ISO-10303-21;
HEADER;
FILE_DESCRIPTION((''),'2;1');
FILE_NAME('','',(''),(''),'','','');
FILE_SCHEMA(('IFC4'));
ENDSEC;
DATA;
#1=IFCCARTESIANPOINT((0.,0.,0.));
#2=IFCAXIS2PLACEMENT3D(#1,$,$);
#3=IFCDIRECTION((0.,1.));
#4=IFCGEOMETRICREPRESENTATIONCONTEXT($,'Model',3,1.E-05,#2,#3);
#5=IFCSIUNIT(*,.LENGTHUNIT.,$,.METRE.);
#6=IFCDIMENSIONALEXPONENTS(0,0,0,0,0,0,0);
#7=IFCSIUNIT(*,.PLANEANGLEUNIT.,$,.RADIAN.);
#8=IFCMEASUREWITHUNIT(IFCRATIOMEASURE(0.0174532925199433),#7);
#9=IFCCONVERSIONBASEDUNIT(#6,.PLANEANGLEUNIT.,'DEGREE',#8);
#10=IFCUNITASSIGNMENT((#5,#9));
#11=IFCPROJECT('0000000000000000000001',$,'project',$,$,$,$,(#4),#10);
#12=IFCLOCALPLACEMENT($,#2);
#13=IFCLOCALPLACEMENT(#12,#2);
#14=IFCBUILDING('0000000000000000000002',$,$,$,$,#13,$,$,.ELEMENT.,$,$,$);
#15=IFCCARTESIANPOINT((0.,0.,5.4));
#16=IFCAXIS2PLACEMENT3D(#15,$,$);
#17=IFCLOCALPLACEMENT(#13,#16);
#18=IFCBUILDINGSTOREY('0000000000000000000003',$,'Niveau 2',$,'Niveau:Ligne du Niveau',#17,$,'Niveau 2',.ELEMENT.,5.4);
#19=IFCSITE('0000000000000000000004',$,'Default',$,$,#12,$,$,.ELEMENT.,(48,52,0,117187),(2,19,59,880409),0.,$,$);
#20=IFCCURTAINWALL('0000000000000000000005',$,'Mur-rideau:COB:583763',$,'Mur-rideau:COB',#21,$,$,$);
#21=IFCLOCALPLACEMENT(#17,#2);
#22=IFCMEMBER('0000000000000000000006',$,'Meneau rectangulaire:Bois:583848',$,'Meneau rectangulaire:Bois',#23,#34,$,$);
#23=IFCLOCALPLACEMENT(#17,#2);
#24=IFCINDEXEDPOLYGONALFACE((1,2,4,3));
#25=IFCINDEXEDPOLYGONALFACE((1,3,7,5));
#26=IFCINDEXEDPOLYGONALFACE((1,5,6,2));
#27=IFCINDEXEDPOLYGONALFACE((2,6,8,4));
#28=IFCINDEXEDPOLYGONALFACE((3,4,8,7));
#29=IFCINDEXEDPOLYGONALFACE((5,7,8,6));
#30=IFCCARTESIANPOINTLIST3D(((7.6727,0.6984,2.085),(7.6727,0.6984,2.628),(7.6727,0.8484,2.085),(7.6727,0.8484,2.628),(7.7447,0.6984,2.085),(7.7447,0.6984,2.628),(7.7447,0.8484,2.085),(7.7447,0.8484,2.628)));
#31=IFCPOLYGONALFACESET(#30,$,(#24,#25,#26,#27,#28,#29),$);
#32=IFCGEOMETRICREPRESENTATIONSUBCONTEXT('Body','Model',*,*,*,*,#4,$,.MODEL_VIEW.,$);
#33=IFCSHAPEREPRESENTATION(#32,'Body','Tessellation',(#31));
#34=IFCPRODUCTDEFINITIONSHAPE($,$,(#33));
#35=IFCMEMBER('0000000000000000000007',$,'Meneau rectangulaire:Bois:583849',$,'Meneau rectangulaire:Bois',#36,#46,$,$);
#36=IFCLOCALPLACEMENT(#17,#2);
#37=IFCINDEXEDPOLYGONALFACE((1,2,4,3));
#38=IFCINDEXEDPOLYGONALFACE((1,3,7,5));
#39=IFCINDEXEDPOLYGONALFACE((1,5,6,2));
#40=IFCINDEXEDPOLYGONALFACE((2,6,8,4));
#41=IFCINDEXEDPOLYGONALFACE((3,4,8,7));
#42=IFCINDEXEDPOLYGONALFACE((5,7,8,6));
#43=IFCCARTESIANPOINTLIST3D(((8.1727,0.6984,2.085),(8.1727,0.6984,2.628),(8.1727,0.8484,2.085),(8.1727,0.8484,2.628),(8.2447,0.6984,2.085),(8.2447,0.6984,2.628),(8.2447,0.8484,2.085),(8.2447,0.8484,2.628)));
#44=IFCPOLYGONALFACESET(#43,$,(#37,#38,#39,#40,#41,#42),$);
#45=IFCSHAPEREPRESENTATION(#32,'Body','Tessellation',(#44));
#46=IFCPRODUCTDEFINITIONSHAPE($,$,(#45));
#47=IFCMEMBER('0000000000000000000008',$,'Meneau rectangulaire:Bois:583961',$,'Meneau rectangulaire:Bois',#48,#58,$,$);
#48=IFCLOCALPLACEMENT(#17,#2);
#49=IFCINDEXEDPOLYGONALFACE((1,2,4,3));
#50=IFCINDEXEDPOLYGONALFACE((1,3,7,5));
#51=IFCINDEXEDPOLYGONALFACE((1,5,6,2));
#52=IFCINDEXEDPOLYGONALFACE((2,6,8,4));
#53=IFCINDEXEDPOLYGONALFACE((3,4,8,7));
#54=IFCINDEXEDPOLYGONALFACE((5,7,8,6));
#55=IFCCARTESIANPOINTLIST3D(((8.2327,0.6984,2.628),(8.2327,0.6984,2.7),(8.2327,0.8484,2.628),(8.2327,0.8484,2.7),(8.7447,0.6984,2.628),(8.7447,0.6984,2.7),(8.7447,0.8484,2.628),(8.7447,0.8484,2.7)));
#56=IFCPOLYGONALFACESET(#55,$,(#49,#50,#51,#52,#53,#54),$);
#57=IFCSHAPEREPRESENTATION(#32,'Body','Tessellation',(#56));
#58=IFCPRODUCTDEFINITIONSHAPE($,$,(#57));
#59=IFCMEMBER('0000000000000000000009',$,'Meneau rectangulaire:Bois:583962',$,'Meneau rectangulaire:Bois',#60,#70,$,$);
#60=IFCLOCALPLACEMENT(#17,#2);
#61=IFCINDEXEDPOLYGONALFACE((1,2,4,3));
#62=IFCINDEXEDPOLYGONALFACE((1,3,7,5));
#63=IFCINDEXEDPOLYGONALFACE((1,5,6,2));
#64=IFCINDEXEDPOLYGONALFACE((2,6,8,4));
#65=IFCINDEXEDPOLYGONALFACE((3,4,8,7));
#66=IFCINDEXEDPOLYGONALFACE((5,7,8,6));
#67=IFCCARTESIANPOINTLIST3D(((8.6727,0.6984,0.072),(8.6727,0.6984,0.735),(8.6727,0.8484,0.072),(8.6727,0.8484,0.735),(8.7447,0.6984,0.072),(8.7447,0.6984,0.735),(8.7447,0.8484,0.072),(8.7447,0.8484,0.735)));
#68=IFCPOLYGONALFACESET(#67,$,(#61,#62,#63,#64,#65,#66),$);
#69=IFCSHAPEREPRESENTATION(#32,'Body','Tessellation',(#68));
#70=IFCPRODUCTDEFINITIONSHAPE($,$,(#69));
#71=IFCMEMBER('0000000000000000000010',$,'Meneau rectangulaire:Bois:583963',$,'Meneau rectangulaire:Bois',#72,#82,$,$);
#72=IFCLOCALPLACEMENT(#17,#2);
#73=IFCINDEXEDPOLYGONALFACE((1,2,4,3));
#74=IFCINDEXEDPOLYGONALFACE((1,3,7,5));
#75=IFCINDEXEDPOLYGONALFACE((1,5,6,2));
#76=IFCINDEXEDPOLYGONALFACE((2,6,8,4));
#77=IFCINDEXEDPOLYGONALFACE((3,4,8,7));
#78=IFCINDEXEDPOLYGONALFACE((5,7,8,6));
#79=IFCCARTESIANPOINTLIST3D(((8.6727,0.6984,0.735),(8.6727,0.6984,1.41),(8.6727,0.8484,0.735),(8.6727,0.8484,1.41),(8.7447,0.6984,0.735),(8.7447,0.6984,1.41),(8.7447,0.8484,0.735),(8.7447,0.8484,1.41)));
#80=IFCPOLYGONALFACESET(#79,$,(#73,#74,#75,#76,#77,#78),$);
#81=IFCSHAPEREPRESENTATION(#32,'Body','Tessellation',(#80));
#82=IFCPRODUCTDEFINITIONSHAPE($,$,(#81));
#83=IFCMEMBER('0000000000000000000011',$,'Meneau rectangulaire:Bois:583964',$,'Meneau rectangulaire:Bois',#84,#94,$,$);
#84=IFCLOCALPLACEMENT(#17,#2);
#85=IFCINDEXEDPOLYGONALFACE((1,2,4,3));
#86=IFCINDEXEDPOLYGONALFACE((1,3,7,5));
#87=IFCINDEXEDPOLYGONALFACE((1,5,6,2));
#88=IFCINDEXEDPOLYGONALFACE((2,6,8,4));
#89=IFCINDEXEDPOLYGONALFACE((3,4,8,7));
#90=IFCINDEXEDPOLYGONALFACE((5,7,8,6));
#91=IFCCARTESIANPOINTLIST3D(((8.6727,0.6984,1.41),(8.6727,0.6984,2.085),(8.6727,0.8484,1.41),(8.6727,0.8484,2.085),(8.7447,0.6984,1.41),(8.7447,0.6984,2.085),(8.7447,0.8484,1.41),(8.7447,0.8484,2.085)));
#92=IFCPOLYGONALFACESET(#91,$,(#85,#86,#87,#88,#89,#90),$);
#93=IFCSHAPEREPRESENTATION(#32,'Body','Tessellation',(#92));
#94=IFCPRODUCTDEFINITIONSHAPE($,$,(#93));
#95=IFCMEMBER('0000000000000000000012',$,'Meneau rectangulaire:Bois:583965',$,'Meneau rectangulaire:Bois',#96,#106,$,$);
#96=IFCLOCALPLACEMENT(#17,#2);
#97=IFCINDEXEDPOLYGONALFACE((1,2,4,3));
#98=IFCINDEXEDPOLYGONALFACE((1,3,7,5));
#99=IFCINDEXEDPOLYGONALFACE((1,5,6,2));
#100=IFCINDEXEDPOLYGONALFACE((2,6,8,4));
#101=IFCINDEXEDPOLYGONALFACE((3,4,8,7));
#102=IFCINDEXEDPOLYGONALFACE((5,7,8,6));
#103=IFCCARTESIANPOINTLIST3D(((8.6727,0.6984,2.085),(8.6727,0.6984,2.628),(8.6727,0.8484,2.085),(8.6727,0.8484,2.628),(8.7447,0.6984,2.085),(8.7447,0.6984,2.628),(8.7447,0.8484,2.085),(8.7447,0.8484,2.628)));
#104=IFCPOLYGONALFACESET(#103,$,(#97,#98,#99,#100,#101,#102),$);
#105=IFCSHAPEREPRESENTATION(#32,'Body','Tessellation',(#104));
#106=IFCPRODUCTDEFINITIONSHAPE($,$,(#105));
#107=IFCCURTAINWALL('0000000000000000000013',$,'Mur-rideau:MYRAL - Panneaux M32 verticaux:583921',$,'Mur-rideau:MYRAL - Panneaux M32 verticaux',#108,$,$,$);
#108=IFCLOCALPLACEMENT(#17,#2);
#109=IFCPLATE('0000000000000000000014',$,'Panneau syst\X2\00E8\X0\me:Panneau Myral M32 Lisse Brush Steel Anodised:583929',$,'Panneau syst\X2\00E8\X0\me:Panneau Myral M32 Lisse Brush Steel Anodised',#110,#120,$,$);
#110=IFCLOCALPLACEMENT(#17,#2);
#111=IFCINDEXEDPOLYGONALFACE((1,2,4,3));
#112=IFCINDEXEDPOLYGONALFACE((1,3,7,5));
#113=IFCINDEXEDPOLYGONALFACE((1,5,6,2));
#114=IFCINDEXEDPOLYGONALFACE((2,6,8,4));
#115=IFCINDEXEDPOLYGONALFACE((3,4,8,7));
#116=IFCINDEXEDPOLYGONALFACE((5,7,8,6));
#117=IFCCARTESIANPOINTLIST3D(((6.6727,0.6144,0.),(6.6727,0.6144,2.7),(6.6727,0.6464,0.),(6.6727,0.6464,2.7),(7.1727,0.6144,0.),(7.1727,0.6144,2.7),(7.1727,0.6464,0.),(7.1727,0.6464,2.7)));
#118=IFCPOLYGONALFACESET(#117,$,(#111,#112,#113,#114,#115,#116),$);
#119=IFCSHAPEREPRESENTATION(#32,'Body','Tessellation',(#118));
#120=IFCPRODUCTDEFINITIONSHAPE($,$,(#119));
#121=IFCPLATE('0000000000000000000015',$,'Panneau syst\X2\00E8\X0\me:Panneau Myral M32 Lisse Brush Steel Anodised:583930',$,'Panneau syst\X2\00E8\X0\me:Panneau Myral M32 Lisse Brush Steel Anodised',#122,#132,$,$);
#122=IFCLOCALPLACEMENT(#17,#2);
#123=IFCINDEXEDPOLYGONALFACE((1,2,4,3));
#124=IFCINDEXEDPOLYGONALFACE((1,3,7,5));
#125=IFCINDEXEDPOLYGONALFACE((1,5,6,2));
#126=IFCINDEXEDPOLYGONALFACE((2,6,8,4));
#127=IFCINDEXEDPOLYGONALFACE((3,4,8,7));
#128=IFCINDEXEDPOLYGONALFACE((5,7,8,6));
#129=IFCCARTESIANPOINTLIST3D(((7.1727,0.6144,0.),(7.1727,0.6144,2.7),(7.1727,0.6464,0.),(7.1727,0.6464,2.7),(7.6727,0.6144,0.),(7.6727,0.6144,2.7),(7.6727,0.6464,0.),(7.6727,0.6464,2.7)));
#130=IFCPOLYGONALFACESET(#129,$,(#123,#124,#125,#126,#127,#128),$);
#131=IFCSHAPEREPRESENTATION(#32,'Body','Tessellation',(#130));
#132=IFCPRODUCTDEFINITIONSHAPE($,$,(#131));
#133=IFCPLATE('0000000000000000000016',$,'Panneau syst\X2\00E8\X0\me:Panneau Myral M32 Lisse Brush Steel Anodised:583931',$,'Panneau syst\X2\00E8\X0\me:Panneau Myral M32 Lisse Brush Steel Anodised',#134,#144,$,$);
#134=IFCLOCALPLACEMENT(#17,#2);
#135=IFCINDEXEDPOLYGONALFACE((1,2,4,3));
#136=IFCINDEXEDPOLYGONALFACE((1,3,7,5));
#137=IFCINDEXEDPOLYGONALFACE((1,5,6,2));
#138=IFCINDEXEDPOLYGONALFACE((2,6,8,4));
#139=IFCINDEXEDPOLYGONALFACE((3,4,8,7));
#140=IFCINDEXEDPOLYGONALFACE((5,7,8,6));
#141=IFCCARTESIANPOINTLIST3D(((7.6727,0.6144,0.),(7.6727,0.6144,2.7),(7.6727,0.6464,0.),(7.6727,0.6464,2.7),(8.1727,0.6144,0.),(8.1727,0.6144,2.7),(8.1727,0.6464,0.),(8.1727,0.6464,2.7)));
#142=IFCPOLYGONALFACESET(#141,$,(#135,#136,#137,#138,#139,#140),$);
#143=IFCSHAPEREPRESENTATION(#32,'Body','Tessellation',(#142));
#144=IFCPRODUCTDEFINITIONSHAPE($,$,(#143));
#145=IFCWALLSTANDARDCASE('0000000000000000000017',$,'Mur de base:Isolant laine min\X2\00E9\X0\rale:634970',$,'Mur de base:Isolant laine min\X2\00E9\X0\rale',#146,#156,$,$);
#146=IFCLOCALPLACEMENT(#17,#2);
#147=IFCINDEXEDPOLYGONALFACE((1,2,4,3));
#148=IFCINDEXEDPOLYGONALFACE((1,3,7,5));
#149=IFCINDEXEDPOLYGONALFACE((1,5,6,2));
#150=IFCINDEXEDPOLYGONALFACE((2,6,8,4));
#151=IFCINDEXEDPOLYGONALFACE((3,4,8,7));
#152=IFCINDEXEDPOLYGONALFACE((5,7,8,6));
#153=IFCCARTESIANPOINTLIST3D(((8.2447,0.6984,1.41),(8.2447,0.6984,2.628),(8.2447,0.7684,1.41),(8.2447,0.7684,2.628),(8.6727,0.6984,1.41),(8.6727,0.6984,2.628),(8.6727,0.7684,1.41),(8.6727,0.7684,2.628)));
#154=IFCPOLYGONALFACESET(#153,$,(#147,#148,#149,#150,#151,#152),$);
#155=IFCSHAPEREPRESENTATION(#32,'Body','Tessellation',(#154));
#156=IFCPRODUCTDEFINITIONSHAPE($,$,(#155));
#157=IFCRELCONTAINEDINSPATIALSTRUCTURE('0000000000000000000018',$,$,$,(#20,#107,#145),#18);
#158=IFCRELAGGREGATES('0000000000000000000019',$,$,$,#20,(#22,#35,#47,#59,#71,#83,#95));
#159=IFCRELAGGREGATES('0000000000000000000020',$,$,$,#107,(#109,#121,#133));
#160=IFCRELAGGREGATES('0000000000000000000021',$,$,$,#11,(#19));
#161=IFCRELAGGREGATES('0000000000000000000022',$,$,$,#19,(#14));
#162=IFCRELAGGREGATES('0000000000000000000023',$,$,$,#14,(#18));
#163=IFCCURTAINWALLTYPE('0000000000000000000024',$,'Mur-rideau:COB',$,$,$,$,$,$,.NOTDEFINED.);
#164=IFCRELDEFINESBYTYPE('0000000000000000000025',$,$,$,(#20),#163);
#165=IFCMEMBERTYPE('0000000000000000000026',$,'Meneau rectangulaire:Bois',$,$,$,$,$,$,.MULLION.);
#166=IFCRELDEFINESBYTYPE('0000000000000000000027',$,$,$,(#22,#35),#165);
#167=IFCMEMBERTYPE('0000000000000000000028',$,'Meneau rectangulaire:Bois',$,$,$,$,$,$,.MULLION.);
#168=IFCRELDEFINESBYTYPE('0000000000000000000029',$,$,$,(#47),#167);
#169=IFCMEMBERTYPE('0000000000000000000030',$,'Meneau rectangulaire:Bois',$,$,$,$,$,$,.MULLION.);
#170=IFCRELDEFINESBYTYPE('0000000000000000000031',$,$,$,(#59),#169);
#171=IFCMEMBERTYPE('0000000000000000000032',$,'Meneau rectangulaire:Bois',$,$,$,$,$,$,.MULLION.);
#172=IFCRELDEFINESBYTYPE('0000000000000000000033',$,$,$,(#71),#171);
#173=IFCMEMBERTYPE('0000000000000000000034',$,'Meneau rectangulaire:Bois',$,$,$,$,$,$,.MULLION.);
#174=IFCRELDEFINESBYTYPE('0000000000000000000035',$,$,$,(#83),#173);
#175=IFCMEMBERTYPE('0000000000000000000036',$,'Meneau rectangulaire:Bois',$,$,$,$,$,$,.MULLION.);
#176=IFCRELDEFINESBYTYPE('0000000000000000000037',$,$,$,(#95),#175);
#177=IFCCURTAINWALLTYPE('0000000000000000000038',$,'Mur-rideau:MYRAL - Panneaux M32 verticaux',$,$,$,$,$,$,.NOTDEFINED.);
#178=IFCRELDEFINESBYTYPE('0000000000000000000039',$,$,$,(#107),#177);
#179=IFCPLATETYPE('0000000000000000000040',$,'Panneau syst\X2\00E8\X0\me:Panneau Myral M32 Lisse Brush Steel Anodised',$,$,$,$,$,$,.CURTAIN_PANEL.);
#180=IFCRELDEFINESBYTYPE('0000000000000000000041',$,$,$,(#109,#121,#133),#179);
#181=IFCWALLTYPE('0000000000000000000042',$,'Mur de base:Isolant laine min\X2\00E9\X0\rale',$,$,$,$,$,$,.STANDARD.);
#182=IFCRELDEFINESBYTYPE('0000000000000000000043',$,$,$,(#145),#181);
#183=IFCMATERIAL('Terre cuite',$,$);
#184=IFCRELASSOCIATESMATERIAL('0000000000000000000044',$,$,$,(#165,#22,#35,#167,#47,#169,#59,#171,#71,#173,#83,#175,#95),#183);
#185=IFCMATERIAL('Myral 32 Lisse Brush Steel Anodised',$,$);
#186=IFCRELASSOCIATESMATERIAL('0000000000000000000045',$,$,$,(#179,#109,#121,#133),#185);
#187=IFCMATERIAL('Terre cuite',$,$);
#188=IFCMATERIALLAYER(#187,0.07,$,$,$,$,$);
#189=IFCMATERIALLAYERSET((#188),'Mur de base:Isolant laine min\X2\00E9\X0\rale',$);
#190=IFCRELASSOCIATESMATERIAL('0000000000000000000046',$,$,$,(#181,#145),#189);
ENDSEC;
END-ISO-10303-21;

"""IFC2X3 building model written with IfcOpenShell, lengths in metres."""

from ifc_helpers import new_model, entity, si_unit, converted_unit, direction, frame, frame_2d, origin, origin_2d_with_axis, place, context, subcontext, project, spatial, rectangle, extrude, source, transform, mapped, material, layer, layer_set, layer_usage, type_object, type_shapes, element, aggregate, save


model = new_model("IFC2X3")

# Units and contexts
model_context = context("Model", 3, precision=1e-05, world=origin(), true_north=direction((0.0, 1.0)))
body_context = subcontext(model_context, "Body", "Model", "MODEL_VIEW")
ifc_project = project(units=[si_unit("LENGTHUNIT", "METRE"), converted_unit("PLANEANGLEUNIT", "DEGREE", entity("IfcRatioMeasure", 0.0174532925199433), si_unit("PLANEANGLEUNIT", "RADIAN"), dimensions=[0, 0, 0, 0, 0, 0, 0])], contexts=[model_context])

# Site, building, storey
site_placement = place(None, origin())
site = spatial("IfcSite", under=ifc_project, at=site_placement, Name="Default", CompositionType="ELEMENT", RefLatitude=(48, 52, 0, 117187), RefLongitude=(2, 19, 59, 880409), RefElevation=0.0)
building_placement = place(site_placement, origin())
building = spatial("IfcBuilding", under=site, at=building_placement, CompositionType="ELEMENT")
storey_placement = place(building_placement, frame((0.0, 0.0, 5.4)))
storey = spatial("IfcBuildingStorey", under=building, at=storey_placement, Name="Niveau 2", ObjectType="Niveau:Ligne du Niveau", LongName="Niveau 2", CompositionType="ELEMENT", Elevation=5.4)

# Curtain wall, members
curtain_wall_type_1 = type_object("IfcCurtainWallType", Name="Mur-rideau:COB", PredefinedType="NOTDEFINED")
curtain_wall_1_placement = place(storey_placement, frame((0.0, 0.0, -5.4)))
curtain_wall_1 = element("IfcCurtainWall", 1, at=curtain_wall_1_placement, inside=storey, type_object=curtain_wall_type_1, Name="Mur-rideau:COB:583763", ObjectType="Mur-rideau:COB")
ifc_material_1 = material(Name="Terre cuite")
member_type_1 = type_object("IfcMemberType", Name="Meneau rectangulaire:Bois", PredefinedType="MULLION", material=ifc_material_1)
shared_shape_1 = source(origin(), body_context, "Body", "SweptSolid", [
    extrude(rectangle(XDim=0.15, YDim=0.072, at=origin_2d_with_axis()), frame((-0.024, 0.0, -0.543), z_axis=(0.0, 0.0, 1.0), x_axis=(0.0, -1.0, 0.0)), (0.0, 0.0, 1.0), 0.543),
])
type_shapes(member_type_1, [shared_shape_1])
member_1_placement = place(storey_placement, frame((7.7327, 0.7734, 2.085), z_axis=(0.0, 0.0, -1.0), x_axis=(1.0, 0.0, 0.0)))
member_1 = element("IfcMember", 2, at=member_1_placement, type_object=member_type_1, material=ifc_material_1, Name="Meneau rectangulaire:Bois:583848", ObjectType="Meneau rectangulaire:Bois", context=body_context, shape_type="MappedRepresentation", body=[
    mapped(shared_shape_1, transform((0.0, 0.0, 0.0), scale=1.0)),
])
member_2_placement = place(storey_placement, frame((8.2327, 0.7734, 2.085), z_axis=(0.0, 0.0, -1.0), x_axis=(1.0, 0.0, 0.0)))
member_2 = element("IfcMember", 3, at=member_2_placement, type_object=member_type_1, material=ifc_material_1, Name="Meneau rectangulaire:Bois:583849", ObjectType="Meneau rectangulaire:Bois", context=body_context, shape_type="MappedRepresentation", body=[
    mapped(shared_shape_1, transform((0.0, 0.0, 0.0), scale=1.0)),
])
member_type_2 = type_object("IfcMemberType", Name="Meneau rectangulaire:Bois", PredefinedType="MULLION", material=ifc_material_1)
shared_shape_2 = source(origin(), body_context, "Body", "SweptSolid", [
    extrude(rectangle(XDim=0.15, YDim=0.072, at=origin_2d_with_axis()), frame((-0.036, 0.0, -0.512), z_axis=(0.0, 0.0, 1.0), x_axis=(0.0, -1.0, 0.0)), (0.0, 0.0, 1.0), 0.512),
])
type_shapes(member_type_2, [shared_shape_2])
member_3_placement = place(storey_placement, frame((8.7447, 0.7734, 2.7), z_axis=(1.0, 0.0, 0.0), x_axis=(0.0, 0.0, 1.0)))
member_3 = element("IfcMember", 4, at=member_3_placement, type_object=member_type_2, material=ifc_material_1, Name="Meneau rectangulaire:Bois:583961", ObjectType="Meneau rectangulaire:Bois", context=body_context, shape_type="MappedRepresentation", body=[
    mapped(shared_shape_2, transform((0.0, 0.0, 0.0), scale=1.0)),
])
member_type_3 = type_object("IfcMemberType", Name="Meneau rectangulaire:Bois", PredefinedType="MULLION", material=ifc_material_1)
shared_shape_3 = source(origin(), body_context, "Body", "SweptSolid", [
    extrude(rectangle(XDim=0.15, YDim=0.072, at=origin_2d_with_axis()), frame((-0.024, 0.0, -0.663), z_axis=(0.0, 0.0, 1.0), x_axis=(0.0, -1.0, 0.0)), (0.0, 0.0, 1.0), 0.663),
])
type_shapes(member_type_3, [shared_shape_3])
member_4_placement = place(storey_placement, frame((8.7327, 0.7734, 0.072), z_axis=(0.0, 0.0, -1.0), x_axis=(1.0, 0.0, 0.0)))
member_4 = element("IfcMember", 5, at=member_4_placement, type_object=member_type_3, material=ifc_material_1, Name="Meneau rectangulaire:Bois:583962", ObjectType="Meneau rectangulaire:Bois", context=body_context, shape_type="MappedRepresentation", body=[
    mapped(shared_shape_3, transform((0.0, 0.0, 0.0), scale=1.0)),
])
member_type_4 = type_object("IfcMemberType", Name="Meneau rectangulaire:Bois", PredefinedType="MULLION", material=ifc_material_1)
shared_shape_4 = source(origin(), body_context, "Body", "SweptSolid", [
    extrude(rectangle(XDim=0.15, YDim=0.072, at=origin_2d_with_axis()), frame((-0.024, 0.0, -0.675), z_axis=(0.0, 0.0, 1.0), x_axis=(0.0, -1.0, 0.0)), (0.0, 0.0, 1.0), 0.675),
])
type_shapes(member_type_4, [shared_shape_4])
member_5_placement = place(storey_placement, frame((8.7327, 0.7734, 0.735), z_axis=(0.0, 0.0, -1.0), x_axis=(1.0, 0.0, 0.0)))
member_5 = element("IfcMember", 6, at=member_5_placement, type_object=member_type_4, material=ifc_material_1, Name="Meneau rectangulaire:Bois:583963", ObjectType="Meneau rectangulaire:Bois", context=body_context, shape_type="MappedRepresentation", body=[
    mapped(shared_shape_4, transform((0.0, 0.0, 0.0), scale=1.0)),
])
member_type_5 = type_object("IfcMemberType", Name="Meneau rectangulaire:Bois", PredefinedType="MULLION", material=ifc_material_1)
shared_shape_5 = source(origin(), body_context, "Body", "SweptSolid", [
    extrude(rectangle(XDim=0.15, YDim=0.072, at=origin_2d_with_axis()), frame((-0.024, 0.0, -0.675), z_axis=(0.0, 0.0, 1.0), x_axis=(0.0, -1.0, 0.0)), (0.0, 0.0, 1.0), 0.675),
])
type_shapes(member_type_5, [shared_shape_5])
member_6_placement = place(storey_placement, frame((8.7327, 0.7734, 1.41), z_axis=(0.0, 0.0, -1.0), x_axis=(1.0, 0.0, 0.0)))
member_6 = element("IfcMember", 7, at=member_6_placement, type_object=member_type_5, material=ifc_material_1, Name="Meneau rectangulaire:Bois:583964", ObjectType="Meneau rectangulaire:Bois", context=body_context, shape_type="MappedRepresentation", body=[
    mapped(shared_shape_5, transform((0.0, 0.0, 0.0), scale=1.0)),
])
member_type_6 = type_object("IfcMemberType", Name="Meneau rectangulaire:Bois", PredefinedType="MULLION", material=ifc_material_1)
shared_shape_6 = source(origin(), body_context, "Body", "SweptSolid", [
    extrude(rectangle(XDim=0.15, YDim=0.072, at=origin_2d_with_axis()), frame((-0.024, 0.0, -0.543), z_axis=(0.0, 0.0, 1.0), x_axis=(0.0, -1.0, 0.0)), (0.0, 0.0, 1.0), 0.543),
])
type_shapes(member_type_6, [shared_shape_6])
member_7_placement = place(storey_placement, frame((8.7327, 0.7734, 2.085), z_axis=(0.0, 0.0, -1.0), x_axis=(1.0, 0.0, 0.0)))
member_7 = element("IfcMember", 8, at=member_7_placement, type_object=member_type_6, material=ifc_material_1, Name="Meneau rectangulaire:Bois:583965", ObjectType="Meneau rectangulaire:Bois", context=body_context, shape_type="MappedRepresentation", body=[
    mapped(shared_shape_6, transform((0.0, 0.0, 0.0), scale=1.0)),
])
aggregate(curtain_wall_1, [member_1, member_2, member_3, member_4, member_5, member_6, member_7])

# Curtain wall, plates
curtain_wall_type_2 = type_object("IfcCurtainWallType", Name="Mur-rideau:MYRAL - Panneaux M32 verticaux", PredefinedType="NOTDEFINED")
curtain_wall_2_placement = place(storey_placement, frame((0.0, 0.0, -5.4)))
curtain_wall_2 = element("IfcCurtainWall", 9, at=curtain_wall_2_placement, inside=storey, type_object=curtain_wall_type_2, Name="Mur-rideau:MYRAL - Panneaux M32 verticaux:583921", ObjectType="Mur-rideau:MYRAL - Panneaux M32 verticaux")
ifc_material_2 = material(Name="Myral 32 Lisse Brush Steel Anodised")
plate_type = type_object("IfcPlateType", Name="Panneau système:Panneau Myral M32 Lisse Brush Steel Anodised", PredefinedType="CURTAIN_PANEL", material=ifc_material_2)
shared_shape_7 = source(origin(), body_context, "Body", "SweptSolid", [
    extrude(rectangle(XDim=0.032, YDim=0.5, at=origin_2d_with_axis()), frame((0.0, -0.016, 0.0), z_axis=(0.0, 0.0, 1.0), x_axis=(0.0, 1.0, 0.0)), (0.0, 0.0, 1.0), 2.7),
])
type_shapes(plate_type, [shared_shape_7])
plate_1_placement = place(curtain_wall_2_placement, frame((6.9227, 0.6464, 5.4)))
plate_1 = element("IfcPlate", 10, at=plate_1_placement, type_object=plate_type, material=ifc_material_2, Name="Panneau système:Panneau Myral M32 Lisse Brush Steel Anodised:583929", ObjectType="Panneau système:Panneau Myral M32 Lisse Brush Steel Anodised", context=body_context, shape_type="MappedRepresentation", body=[
    mapped(shared_shape_7, transform((0.0, 0.0, 0.0), scale=1.0)),
])
plate_2_placement = place(curtain_wall_2_placement, frame((7.4227, 0.6464, 5.4)))
plate_2 = element("IfcPlate", 11, at=plate_2_placement, type_object=plate_type, material=ifc_material_2, Name="Panneau système:Panneau Myral M32 Lisse Brush Steel Anodised:583930", ObjectType="Panneau système:Panneau Myral M32 Lisse Brush Steel Anodised", context=body_context, shape_type="MappedRepresentation", body=[
    mapped(shared_shape_7, transform((0.0, 0.0, 0.0), scale=1.0)),
])
plate_3_placement = place(curtain_wall_2_placement, frame((7.9227, 0.6464, 5.4)))
plate_3 = element("IfcPlate", 12, at=plate_3_placement, type_object=plate_type, material=ifc_material_2, Name="Panneau système:Panneau Myral M32 Lisse Brush Steel Anodised:583931", ObjectType="Panneau système:Panneau Myral M32 Lisse Brush Steel Anodised", context=body_context, shape_type="MappedRepresentation", body=[
    mapped(shared_shape_7, transform((0.0, 0.0, 0.0), scale=1.0)),
])
aggregate(curtain_wall_2, [plate_1, plate_2, plate_3])

# Wall
ifc_material_3 = material(Name="Terre cuite")
ifc_layer = layer(ifc_material_3, 0.07)
ifc_layer_set = layer_set([ifc_layer], Name="Mur de base:Isolant laine minérale")
ifc_layer_usage = layer_usage(ifc_layer_set, "AXIS2", "NEGATIVE", 0.035)
wall_type = type_object("IfcWallType", Name="Mur de base:Isolant laine minérale", PredefinedType="STANDARD", material=ifc_layer_set)
wall_placement = place(storey_placement, frame((8.2447, 0.7334, 1.41)))
element("IfcWallStandardCase", 13, at=wall_placement, inside=storey, type_object=wall_type, material=ifc_layer_usage, Name="Mur de base:Isolant laine minérale:634970", ObjectType="Mur de base:Isolant laine minérale", context=body_context, shape_type="SweptSolid", body=[
    extrude(rectangle(XDim=0.428, YDim=0.07, at=frame_2d((0.214, 0.0), x_axis=(-1.0, 0.0))), origin(), (0.0, 0.0, 1.0), 1.218),
])

save(model, "model.ifc")
